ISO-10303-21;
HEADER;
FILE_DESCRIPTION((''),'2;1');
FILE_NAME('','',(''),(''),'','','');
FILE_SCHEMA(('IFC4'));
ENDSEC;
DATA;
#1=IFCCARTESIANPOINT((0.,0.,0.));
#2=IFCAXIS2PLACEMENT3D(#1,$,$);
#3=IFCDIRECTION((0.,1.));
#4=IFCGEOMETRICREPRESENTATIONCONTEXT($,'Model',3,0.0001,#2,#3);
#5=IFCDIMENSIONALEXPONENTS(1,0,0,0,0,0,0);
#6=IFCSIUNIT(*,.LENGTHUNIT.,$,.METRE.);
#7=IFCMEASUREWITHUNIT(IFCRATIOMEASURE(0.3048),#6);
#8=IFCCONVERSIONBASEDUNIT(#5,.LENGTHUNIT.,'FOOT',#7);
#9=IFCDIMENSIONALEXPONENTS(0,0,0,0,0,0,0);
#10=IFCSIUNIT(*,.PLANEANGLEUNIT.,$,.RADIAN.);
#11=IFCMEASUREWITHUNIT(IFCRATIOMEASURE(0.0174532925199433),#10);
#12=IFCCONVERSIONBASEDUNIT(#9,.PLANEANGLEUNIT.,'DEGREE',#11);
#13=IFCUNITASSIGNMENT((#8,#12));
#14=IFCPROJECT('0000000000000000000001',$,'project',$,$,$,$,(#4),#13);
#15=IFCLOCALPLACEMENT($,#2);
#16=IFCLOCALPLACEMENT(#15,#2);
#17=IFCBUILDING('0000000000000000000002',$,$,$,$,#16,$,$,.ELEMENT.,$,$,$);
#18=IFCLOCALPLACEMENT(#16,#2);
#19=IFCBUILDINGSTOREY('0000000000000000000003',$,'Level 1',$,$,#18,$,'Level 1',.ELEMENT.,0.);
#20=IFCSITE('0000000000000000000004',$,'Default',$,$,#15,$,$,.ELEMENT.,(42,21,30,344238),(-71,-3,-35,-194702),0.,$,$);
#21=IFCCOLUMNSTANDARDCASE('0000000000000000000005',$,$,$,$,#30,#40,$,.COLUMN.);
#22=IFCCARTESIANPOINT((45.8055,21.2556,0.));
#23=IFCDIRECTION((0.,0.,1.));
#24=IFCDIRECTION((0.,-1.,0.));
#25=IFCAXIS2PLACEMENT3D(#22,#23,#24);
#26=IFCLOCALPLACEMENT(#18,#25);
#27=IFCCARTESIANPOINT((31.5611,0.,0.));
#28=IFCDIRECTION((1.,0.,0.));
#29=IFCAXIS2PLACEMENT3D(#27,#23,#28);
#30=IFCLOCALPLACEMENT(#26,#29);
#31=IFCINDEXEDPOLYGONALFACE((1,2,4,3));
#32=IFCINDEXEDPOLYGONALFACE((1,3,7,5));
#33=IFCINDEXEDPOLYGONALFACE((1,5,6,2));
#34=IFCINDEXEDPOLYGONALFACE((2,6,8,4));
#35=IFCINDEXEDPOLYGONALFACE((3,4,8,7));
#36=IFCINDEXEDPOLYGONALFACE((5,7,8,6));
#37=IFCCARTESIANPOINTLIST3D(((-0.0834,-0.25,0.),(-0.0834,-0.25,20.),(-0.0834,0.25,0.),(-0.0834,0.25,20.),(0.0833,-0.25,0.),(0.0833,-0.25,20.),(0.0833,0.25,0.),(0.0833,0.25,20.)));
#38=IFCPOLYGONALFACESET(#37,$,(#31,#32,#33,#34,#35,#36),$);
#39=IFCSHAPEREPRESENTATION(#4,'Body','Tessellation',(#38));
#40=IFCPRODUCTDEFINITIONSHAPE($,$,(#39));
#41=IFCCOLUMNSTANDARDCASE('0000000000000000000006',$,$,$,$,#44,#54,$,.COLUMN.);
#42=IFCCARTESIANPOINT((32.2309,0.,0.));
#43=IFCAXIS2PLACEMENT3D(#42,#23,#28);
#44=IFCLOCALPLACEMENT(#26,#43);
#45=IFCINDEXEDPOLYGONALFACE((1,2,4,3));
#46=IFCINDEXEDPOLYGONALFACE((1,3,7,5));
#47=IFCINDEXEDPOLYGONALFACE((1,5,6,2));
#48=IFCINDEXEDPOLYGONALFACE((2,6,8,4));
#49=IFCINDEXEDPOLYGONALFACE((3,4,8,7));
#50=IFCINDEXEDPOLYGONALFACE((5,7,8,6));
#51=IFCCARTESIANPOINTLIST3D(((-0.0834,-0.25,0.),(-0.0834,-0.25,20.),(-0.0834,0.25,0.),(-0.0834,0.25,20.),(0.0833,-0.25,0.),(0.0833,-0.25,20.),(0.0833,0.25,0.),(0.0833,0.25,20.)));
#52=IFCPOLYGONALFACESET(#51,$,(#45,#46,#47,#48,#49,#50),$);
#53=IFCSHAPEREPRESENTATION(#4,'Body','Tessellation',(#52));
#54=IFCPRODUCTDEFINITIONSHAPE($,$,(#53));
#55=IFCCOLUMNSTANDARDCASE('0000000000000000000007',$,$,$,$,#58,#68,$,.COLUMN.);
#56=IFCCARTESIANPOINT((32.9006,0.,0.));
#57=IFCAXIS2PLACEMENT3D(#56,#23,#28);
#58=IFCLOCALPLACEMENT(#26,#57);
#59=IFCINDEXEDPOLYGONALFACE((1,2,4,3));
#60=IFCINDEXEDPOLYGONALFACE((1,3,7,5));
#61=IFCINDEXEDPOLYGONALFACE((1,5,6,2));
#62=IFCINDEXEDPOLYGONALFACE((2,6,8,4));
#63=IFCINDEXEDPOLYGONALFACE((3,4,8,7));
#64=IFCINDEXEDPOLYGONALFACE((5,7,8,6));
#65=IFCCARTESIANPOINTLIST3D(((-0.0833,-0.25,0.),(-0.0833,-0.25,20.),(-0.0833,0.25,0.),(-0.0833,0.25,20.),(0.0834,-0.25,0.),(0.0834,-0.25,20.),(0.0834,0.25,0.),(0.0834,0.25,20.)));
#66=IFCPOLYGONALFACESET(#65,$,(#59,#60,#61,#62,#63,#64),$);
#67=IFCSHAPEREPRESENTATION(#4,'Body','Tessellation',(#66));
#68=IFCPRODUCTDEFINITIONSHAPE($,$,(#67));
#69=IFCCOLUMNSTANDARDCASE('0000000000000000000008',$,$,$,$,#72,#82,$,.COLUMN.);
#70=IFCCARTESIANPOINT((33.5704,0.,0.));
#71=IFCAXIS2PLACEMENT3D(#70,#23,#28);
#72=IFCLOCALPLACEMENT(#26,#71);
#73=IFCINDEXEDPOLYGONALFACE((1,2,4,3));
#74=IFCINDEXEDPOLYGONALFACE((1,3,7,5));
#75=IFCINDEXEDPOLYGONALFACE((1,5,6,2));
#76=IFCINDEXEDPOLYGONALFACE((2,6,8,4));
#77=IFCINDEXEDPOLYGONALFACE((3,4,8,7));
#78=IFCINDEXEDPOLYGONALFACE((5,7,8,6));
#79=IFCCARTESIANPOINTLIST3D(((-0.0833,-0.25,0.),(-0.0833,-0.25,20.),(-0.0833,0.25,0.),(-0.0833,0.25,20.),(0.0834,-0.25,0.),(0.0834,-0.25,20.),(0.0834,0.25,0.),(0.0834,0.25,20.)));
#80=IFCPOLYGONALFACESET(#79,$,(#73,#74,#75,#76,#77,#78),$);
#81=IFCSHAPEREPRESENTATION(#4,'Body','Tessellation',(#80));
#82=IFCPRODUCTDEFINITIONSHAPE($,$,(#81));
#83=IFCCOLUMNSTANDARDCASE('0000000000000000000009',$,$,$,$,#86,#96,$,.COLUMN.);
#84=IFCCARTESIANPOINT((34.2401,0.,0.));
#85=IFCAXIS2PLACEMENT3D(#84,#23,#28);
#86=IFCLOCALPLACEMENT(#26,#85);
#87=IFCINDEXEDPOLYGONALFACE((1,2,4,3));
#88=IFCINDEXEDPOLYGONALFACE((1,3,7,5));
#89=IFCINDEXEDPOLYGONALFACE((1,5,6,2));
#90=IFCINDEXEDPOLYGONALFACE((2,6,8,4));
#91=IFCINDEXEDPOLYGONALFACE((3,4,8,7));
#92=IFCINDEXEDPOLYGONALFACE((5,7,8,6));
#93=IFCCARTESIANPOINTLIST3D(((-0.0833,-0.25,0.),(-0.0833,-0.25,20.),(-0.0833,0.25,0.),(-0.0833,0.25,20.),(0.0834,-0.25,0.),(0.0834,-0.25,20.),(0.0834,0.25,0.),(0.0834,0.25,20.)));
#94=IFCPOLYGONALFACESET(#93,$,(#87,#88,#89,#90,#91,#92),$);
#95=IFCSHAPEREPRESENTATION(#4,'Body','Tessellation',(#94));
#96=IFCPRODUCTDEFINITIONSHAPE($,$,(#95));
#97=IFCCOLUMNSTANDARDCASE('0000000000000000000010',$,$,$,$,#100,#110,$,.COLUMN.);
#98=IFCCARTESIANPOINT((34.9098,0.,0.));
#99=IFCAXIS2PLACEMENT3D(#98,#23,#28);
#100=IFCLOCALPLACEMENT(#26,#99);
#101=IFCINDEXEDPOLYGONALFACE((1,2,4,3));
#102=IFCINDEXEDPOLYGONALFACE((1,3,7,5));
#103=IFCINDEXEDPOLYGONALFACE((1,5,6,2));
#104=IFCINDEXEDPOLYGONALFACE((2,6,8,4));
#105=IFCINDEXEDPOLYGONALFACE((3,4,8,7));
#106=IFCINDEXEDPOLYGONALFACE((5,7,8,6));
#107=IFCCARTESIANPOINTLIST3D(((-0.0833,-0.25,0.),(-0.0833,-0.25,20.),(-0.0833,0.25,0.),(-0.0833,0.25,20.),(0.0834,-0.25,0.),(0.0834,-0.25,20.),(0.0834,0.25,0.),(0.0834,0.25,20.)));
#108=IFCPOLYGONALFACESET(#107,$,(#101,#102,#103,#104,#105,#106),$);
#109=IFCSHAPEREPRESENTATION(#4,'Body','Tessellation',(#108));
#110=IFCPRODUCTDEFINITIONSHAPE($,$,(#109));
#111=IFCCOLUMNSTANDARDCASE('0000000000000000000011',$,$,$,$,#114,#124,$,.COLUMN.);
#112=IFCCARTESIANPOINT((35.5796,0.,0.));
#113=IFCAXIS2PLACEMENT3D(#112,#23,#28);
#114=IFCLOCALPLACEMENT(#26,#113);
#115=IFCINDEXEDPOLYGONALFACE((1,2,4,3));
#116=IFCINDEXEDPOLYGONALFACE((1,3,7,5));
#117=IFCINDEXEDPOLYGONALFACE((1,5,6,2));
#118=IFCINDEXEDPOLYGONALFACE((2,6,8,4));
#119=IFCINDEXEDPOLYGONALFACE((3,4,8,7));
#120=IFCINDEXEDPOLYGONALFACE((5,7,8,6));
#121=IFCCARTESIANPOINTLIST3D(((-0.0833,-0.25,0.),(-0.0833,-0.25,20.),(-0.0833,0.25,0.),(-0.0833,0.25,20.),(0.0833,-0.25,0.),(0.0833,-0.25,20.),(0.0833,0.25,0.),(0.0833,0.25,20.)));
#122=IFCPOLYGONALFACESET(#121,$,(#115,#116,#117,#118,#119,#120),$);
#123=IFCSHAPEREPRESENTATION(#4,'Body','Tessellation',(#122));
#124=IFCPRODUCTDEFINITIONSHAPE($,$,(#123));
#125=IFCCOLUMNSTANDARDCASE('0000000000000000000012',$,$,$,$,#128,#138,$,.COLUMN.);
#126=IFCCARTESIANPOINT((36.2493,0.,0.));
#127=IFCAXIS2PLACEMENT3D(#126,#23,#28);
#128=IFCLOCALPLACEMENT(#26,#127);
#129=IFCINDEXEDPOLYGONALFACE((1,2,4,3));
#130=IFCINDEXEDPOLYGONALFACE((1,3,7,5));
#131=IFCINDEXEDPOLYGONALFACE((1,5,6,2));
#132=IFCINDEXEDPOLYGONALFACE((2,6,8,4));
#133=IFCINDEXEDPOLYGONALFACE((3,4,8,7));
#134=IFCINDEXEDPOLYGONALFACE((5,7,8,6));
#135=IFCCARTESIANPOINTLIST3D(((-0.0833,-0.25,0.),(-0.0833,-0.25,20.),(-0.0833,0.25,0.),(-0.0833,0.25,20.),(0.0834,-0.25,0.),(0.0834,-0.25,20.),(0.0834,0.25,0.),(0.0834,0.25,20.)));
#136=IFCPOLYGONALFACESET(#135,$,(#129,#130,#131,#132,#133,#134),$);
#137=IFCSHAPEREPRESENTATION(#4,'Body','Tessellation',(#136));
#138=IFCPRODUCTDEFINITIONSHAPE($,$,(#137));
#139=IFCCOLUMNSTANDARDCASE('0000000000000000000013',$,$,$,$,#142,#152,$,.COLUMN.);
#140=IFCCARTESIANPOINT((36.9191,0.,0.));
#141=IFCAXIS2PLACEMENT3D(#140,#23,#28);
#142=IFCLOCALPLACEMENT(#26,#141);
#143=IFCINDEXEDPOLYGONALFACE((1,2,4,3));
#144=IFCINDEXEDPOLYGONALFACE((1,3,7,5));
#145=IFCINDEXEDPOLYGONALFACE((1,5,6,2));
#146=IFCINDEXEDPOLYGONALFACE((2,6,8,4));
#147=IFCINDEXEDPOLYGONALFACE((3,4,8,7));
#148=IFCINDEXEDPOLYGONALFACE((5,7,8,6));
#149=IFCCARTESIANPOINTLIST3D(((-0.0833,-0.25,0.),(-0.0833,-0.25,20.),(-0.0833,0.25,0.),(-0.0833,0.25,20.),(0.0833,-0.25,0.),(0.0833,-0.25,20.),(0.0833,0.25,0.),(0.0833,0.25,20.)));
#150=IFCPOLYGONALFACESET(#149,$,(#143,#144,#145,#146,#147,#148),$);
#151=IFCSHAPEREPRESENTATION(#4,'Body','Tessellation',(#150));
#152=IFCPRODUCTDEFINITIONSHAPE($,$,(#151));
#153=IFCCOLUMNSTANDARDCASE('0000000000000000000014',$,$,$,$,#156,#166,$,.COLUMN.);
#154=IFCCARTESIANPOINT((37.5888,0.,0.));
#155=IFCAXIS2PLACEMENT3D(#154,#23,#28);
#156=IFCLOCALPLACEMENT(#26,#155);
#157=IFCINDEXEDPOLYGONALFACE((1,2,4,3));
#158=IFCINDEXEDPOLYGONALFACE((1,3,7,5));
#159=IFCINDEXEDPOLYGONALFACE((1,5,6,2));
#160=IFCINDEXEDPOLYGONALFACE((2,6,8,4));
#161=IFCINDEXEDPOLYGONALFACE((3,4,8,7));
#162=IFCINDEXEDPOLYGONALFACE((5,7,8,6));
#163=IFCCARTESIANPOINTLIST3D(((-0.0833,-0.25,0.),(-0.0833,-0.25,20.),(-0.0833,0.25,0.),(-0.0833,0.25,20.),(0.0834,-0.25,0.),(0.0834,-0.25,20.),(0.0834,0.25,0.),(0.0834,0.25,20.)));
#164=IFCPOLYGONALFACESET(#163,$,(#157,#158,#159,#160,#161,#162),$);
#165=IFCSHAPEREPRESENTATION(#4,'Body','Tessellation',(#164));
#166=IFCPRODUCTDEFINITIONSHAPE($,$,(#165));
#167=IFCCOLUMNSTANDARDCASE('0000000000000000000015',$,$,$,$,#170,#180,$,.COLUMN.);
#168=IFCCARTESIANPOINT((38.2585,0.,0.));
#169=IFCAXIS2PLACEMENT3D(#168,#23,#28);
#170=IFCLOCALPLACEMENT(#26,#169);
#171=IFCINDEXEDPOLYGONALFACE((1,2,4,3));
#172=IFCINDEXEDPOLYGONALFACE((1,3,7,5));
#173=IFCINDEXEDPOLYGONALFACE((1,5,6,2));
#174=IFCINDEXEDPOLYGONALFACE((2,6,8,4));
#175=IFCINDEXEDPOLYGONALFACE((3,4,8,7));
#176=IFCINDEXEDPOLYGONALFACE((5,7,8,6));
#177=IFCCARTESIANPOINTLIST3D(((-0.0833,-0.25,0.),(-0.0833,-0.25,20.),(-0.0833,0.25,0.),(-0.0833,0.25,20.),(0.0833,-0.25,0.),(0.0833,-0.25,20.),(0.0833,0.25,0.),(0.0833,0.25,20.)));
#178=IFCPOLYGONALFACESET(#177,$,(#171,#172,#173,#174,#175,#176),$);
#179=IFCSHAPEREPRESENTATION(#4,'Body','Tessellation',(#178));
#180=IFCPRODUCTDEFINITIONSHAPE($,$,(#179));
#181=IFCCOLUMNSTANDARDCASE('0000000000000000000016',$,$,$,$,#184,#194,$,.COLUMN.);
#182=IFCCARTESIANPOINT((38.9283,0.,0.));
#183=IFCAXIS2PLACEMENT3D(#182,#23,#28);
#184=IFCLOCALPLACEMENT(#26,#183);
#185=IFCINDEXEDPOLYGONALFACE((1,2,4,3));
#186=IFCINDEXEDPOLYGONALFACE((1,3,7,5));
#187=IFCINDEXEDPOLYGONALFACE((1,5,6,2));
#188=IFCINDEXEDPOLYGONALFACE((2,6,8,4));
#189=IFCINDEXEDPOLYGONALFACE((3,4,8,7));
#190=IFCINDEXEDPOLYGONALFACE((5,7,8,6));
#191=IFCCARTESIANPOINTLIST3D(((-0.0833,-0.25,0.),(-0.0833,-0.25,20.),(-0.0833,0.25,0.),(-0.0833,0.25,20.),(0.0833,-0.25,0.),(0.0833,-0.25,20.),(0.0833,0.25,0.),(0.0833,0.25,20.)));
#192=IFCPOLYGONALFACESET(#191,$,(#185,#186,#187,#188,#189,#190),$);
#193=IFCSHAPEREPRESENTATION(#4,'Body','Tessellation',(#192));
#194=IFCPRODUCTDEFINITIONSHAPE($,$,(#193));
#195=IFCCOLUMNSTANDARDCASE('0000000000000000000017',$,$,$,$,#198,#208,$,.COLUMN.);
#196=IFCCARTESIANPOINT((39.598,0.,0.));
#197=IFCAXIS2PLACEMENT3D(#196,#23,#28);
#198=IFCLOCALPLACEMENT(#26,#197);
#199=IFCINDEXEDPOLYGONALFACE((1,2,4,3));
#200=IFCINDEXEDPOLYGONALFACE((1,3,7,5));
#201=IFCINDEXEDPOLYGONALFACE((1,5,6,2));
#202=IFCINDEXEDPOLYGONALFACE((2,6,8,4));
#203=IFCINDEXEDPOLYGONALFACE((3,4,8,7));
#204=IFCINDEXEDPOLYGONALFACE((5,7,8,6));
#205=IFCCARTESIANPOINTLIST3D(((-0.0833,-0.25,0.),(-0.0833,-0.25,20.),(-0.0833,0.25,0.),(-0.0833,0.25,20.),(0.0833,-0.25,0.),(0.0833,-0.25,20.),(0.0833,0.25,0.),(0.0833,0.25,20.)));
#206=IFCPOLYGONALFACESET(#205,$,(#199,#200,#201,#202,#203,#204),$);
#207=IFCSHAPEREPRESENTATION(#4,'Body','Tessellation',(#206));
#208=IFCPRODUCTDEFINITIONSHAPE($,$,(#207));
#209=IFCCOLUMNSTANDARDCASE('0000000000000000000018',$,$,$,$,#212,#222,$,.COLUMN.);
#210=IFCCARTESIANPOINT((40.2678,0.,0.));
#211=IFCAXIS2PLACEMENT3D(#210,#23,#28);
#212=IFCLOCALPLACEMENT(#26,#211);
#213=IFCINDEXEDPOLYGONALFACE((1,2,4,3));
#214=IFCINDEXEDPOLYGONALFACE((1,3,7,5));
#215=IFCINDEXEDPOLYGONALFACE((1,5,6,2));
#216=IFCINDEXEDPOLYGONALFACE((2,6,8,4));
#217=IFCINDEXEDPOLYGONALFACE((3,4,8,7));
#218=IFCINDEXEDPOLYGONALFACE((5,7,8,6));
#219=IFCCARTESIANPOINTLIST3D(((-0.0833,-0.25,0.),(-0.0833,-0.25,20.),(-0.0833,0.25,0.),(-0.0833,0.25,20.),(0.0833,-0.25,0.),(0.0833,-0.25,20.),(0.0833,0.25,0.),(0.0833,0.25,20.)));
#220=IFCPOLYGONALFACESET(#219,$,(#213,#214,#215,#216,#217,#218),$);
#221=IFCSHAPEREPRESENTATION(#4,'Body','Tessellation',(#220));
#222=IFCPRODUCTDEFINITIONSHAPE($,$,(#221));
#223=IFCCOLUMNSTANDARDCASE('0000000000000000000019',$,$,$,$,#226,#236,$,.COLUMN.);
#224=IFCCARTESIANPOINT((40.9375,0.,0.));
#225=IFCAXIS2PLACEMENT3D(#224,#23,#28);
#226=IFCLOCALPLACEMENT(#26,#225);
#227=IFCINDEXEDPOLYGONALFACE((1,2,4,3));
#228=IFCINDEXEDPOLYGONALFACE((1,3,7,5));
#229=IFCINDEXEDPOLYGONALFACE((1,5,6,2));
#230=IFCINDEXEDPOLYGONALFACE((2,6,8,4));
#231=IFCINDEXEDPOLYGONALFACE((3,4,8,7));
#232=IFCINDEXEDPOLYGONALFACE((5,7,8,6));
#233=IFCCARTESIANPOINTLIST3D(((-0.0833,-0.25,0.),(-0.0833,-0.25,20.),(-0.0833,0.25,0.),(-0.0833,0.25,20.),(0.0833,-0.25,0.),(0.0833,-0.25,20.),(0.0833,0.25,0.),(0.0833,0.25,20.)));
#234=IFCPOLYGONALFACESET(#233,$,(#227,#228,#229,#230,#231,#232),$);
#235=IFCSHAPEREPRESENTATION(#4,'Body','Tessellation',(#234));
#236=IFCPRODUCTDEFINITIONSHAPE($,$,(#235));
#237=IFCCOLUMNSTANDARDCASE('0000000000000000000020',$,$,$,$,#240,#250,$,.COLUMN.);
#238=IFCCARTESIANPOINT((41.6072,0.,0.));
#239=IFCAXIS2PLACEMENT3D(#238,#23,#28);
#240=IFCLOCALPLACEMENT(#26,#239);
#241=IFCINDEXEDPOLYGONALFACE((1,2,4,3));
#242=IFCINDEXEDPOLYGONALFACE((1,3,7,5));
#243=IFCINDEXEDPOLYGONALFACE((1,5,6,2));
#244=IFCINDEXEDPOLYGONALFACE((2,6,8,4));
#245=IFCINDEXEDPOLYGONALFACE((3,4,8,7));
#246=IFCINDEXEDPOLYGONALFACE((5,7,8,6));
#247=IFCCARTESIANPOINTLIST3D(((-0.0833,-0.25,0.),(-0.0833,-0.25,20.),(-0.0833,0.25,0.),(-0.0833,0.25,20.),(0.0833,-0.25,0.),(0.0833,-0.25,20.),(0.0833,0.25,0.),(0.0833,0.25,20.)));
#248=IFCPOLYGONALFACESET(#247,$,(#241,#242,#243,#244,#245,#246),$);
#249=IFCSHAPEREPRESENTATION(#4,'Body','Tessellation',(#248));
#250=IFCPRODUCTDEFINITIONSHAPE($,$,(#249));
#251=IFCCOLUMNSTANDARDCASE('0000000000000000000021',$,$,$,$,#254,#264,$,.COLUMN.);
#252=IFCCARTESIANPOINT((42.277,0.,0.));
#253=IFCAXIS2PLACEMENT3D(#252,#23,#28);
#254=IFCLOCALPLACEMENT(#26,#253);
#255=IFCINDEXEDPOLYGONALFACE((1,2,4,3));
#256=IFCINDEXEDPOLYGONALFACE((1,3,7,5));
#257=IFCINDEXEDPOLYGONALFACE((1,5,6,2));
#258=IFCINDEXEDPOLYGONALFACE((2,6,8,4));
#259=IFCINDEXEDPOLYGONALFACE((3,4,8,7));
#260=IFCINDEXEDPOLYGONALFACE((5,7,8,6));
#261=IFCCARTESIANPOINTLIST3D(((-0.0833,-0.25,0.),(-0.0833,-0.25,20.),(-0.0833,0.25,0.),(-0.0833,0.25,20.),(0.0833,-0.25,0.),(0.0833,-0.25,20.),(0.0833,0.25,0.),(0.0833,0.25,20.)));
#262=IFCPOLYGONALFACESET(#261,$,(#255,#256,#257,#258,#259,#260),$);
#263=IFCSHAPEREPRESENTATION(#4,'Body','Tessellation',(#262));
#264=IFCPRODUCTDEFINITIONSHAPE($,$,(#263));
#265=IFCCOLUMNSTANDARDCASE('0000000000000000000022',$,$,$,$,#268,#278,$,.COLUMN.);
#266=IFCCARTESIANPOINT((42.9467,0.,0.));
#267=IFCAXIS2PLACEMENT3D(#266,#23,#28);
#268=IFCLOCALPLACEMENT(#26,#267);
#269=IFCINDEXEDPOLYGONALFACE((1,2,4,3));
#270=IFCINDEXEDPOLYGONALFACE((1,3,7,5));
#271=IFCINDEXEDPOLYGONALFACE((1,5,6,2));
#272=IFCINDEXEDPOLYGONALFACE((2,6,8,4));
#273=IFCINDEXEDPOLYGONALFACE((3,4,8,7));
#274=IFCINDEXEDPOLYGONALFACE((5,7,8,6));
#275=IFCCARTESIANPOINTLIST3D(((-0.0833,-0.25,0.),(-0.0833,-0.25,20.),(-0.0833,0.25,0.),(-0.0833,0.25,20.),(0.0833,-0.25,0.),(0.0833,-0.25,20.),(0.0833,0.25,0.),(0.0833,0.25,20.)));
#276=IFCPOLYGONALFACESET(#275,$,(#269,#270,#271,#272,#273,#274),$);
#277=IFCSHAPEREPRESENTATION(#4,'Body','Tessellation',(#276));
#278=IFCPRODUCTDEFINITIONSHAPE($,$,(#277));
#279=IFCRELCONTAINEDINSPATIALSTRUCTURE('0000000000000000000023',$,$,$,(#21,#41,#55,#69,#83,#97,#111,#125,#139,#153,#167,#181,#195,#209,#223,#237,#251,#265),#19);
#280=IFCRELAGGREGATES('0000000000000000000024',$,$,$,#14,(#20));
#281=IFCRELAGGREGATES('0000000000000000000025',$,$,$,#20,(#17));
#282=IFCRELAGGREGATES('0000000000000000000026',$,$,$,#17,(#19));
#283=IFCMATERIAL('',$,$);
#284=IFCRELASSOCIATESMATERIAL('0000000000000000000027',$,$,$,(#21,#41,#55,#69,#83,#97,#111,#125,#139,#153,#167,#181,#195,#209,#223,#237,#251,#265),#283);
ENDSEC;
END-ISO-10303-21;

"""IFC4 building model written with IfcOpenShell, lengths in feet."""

from ifc_helpers import new_model, entity, si_unit, converted_unit, direction, frame, origin, place, context, project, spatial, rectangle, extrude, material, element, save


model = new_model("IFC4")

# Units and contexts
model_context = context("Model", 3, precision=0.0001, world=origin(), true_north=direction((0.0, 1.0)))
ifc_project = project(units=[converted_unit("LENGTHUNIT", "FOOT", entity("IfcRatioMeasure", 0.3048), si_unit("LENGTHUNIT", "METRE"), dimensions=[1, 0, 0, 0, 0, 0, 0]), converted_unit("PLANEANGLEUNIT", "DEGREE", entity("IfcRatioMeasure", 0.0174532925199433), si_unit("PLANEANGLEUNIT", "RADIAN"), dimensions=[0, 0, 0, 0, 0, 0, 0])], contexts=[model_context])

# Site, building, storey
site_placement = place(None, origin())
site = spatial("IfcSite", under=ifc_project, at=site_placement, Name="Default", CompositionType="ELEMENT", RefLatitude=(42, 21, 30, 344238), RefLongitude=(-71, -3, -35, -194702), RefElevation=0.0)
building_placement = place(site_placement, origin())
building = spatial("IfcBuilding", under=site, at=building_placement, CompositionType="ELEMENT")
storey_placement = place(building_placement, origin())
storey = spatial("IfcBuildingStorey", under=building, at=storey_placement, Name="Level 1", LongName="Level 1", CompositionType="ELEMENT", Elevation=0.0)

# Columns
ifc_material_1 = material(Name="")
placement = place(storey_placement, frame((45.8055, 21.2556, 0.0), z_axis=(0.0, 0.0, 1.0), x_axis=(0.0, -1.0, 0.0)))
for number, where, z_axis, x_axis in (
    (1, (31.5611, 0.0, 0.0), (0.0, 0.0, 1.0), (1.0, 0.0, 0.0)),
    (2, (32.2309, 0.0, 0.0), (0.0, 0.0, 1.0), (1.0, 0.0, 0.0)),
    (3, (32.9006, 0.0, 0.0), (0.0, 0.0, 1.0), (1.0, 0.0, 0.0)),
    (4, (33.5704, 0.0, 0.0), (0.0, 0.0, 1.0), (1.0, 0.0, 0.0)),
    (5, (34.2401, 0.0, 0.0), (0.0, 0.0, 1.0), (1.0, 0.0, 0.0)),
    (6, (34.9098, 0.0, 0.0), (0.0, 0.0, 1.0), (1.0, 0.0, 0.0)),
    (7, (35.5796, 0.0, 0.0), (0.0, 0.0, 1.0), (1.0, 0.0, 0.0)),
    (8, (36.2493, 0.0, 0.0), (0.0, 0.0, 1.0), (1.0, 0.0, 0.0)),
    (9, (36.9191, 0.0, 0.0), (0.0, 0.0, 1.0), (1.0, 0.0, 0.0)),
    (10, (37.5888, 0.0, 0.0), (0.0, 0.0, 1.0), (1.0, 0.0, 0.0)),
    (11, (38.2585, 0.0, 0.0), (0.0, 0.0, 1.0), (1.0, 0.0, 0.0)),
    (12, (38.9283, 0.0, 0.0), (0.0, 0.0, 1.0), (1.0, 0.0, 0.0)),
    (13, (39.598, 0.0, 0.0), (0.0, 0.0, 1.0), (1.0, 0.0, 0.0)),
    (14, (40.2678, 0.0, 0.0), (0.0, 0.0, 1.0), (1.0, 0.0, 0.0)),
    (15, (40.9375, 0.0, 0.0), (0.0, 0.0, 1.0), (1.0, 0.0, 0.0)),
    (16, (41.6072, 0.0, 0.0), (0.0, 0.0, 1.0), (1.0, 0.0, 0.0)),
    (17, (42.277, 0.0, 0.0), (0.0, 0.0, 1.0), (1.0, 0.0, 0.0)),
    (18, (42.9467, 0.0, 0.0), (0.0, 0.0, 1.0), (1.0, 0.0, 0.0)),
):
    element("IfcColumnStandardCase", number, at=place(placement, frame(where, z_axis=z_axis, x_axis=x_axis)), inside=storey, material=ifc_material_1, PredefinedType="COLUMN", context=model_context, shape_type="SweptSolid", body=[
        extrude(rectangle(XDim=0.1667, YDim=0.5), origin(), (0.0, 0.0, 1.0), 20.0),
    ])

save(model, "model.ifc")
